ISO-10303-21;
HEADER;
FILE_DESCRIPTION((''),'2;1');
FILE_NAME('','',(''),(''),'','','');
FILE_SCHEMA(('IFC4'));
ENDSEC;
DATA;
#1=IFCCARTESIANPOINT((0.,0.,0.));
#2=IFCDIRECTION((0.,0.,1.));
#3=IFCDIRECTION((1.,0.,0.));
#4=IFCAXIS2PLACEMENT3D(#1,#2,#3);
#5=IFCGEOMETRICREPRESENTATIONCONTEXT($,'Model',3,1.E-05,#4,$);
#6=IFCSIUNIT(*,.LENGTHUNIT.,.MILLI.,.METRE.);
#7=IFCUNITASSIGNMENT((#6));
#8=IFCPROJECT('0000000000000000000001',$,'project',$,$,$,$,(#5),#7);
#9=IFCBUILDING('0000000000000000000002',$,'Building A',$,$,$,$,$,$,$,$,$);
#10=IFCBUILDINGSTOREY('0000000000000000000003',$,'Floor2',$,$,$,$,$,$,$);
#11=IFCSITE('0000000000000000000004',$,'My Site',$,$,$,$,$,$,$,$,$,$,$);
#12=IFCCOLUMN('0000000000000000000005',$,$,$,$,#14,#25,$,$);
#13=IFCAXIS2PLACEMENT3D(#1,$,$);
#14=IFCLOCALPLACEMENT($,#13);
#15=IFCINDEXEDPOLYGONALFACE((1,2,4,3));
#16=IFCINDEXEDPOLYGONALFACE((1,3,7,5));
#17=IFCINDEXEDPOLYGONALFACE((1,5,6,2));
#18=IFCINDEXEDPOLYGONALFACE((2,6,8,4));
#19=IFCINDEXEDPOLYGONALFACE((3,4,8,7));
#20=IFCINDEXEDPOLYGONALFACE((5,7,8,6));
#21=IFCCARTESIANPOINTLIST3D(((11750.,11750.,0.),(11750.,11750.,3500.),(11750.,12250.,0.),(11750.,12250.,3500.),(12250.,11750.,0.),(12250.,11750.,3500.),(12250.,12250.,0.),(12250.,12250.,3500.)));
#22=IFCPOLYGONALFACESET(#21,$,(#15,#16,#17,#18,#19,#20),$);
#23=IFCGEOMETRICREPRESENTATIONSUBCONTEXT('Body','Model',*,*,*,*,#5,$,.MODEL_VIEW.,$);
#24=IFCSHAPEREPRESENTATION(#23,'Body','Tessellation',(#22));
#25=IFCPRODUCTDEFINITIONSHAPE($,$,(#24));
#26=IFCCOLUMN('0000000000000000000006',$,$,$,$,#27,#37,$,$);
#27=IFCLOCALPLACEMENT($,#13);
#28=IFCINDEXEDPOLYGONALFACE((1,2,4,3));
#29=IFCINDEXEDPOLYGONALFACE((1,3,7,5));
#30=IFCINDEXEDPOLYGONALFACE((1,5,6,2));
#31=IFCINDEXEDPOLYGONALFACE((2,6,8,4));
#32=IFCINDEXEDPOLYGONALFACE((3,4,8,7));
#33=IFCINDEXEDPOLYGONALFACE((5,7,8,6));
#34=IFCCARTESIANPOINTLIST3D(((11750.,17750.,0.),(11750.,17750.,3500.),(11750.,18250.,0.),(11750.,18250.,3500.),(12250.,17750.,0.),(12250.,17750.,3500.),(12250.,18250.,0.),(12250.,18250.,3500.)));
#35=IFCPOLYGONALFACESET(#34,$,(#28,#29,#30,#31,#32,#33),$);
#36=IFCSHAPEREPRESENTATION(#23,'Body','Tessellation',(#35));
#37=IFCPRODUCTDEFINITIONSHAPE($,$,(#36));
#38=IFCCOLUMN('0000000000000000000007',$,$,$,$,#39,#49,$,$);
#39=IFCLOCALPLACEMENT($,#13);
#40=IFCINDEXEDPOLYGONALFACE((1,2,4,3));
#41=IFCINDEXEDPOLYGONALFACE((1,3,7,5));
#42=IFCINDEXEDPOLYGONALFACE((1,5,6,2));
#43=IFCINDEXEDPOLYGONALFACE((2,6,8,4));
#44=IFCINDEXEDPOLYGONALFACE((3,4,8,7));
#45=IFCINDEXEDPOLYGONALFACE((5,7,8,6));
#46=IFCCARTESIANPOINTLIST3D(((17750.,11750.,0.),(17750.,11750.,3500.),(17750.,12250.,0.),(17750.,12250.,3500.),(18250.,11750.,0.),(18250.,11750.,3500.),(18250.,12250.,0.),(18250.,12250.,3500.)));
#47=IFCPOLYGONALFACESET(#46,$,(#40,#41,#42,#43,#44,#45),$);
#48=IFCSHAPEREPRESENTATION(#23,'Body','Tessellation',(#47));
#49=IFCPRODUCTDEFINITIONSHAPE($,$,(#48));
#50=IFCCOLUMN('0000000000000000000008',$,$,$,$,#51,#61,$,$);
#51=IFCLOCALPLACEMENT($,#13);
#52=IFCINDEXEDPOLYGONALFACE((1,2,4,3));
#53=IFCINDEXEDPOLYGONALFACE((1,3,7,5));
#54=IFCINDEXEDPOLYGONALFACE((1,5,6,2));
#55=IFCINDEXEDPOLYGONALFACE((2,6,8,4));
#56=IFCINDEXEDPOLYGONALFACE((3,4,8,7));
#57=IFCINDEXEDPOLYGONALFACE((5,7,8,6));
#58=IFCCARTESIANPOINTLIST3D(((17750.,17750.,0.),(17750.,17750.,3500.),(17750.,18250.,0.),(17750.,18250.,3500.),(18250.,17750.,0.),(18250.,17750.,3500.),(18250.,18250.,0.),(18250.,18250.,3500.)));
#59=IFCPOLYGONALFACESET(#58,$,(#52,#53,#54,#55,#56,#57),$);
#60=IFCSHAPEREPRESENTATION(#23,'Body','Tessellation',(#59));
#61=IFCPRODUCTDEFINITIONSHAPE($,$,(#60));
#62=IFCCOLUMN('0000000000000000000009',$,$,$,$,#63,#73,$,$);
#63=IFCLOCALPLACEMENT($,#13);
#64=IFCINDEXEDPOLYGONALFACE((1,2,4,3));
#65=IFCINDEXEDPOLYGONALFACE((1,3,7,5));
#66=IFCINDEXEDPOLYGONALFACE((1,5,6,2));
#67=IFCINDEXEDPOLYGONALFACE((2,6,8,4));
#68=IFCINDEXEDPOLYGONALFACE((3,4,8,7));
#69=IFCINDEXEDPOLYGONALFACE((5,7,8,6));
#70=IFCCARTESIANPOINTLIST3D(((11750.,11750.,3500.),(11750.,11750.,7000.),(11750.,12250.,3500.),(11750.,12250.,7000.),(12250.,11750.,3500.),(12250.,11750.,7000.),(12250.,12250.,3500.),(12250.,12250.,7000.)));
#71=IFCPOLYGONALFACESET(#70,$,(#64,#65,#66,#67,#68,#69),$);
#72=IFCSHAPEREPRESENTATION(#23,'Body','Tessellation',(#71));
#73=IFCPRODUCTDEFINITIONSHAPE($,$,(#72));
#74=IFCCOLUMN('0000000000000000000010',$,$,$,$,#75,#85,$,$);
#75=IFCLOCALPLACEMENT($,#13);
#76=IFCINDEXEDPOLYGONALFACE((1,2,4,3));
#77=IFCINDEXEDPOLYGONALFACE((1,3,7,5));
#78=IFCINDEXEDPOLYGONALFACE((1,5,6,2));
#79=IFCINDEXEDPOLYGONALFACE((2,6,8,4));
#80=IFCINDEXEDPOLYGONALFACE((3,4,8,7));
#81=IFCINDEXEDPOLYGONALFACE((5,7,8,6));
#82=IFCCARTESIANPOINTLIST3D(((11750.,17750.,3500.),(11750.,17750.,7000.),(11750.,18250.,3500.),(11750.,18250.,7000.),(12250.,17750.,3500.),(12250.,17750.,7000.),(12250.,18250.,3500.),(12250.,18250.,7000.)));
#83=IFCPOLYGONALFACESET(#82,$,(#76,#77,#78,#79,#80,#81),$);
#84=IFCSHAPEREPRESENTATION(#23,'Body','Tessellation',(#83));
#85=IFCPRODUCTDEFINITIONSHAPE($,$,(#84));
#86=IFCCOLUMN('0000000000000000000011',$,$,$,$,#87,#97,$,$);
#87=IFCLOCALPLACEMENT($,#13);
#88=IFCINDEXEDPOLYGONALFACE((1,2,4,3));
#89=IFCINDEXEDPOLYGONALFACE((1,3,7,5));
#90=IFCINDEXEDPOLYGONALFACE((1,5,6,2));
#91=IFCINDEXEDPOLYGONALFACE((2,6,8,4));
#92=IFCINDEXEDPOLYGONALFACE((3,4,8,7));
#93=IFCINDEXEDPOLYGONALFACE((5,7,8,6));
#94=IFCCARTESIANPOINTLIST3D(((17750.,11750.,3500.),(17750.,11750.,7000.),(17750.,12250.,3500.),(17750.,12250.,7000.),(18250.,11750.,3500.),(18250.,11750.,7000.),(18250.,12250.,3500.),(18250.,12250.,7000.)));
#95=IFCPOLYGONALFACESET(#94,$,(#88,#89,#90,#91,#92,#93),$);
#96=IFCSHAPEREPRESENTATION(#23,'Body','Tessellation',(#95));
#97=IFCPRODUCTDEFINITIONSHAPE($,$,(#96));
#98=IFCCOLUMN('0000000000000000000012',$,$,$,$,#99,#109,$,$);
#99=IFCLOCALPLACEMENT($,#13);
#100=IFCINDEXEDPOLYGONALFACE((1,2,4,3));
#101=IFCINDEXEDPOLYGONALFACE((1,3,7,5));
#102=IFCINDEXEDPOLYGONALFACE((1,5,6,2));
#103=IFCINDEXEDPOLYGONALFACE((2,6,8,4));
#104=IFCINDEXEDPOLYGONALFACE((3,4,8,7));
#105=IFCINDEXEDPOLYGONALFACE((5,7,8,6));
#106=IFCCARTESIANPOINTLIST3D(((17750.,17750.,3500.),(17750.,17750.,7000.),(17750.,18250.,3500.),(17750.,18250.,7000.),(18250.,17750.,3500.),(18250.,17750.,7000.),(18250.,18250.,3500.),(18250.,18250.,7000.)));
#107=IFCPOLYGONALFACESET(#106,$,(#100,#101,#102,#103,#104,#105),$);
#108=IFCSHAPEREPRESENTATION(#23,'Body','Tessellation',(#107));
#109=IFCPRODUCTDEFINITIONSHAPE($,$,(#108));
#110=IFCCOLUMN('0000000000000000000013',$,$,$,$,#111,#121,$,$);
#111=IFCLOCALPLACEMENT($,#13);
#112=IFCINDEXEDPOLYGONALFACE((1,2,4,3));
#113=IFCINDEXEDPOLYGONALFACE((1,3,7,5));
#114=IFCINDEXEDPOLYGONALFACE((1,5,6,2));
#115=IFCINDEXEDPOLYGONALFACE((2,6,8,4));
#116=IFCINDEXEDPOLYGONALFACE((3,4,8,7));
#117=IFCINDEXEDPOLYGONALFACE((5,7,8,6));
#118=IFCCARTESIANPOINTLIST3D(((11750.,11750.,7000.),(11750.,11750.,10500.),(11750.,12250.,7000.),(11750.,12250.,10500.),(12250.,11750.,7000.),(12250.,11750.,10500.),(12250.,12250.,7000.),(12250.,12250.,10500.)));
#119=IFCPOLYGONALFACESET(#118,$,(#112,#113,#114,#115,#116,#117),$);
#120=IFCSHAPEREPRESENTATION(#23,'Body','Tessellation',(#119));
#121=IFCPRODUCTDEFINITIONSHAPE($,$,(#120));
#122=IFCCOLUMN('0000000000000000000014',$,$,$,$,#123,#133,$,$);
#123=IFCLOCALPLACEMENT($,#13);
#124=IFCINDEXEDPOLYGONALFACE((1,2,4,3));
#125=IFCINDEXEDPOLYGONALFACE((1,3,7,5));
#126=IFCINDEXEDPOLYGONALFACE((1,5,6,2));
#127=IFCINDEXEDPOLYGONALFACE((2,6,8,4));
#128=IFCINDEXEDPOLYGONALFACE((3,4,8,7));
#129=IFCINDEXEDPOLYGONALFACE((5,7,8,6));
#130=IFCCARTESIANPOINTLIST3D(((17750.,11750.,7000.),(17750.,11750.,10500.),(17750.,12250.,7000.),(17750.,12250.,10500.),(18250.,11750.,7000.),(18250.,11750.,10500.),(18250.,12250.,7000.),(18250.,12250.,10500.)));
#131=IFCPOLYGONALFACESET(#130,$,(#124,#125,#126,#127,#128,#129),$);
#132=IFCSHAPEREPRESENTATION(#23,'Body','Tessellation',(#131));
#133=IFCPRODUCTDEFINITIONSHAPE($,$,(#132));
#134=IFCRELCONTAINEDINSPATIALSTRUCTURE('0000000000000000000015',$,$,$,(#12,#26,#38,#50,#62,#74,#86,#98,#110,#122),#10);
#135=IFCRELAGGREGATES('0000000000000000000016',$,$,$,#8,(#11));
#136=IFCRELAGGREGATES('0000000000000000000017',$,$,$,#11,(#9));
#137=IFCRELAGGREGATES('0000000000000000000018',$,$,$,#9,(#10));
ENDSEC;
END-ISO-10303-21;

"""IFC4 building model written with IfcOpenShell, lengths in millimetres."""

from ifc_helpers import new_model, si_unit, frame, origin_with_axes, place, context, subcontext, project, spatial, line, indexed_curve, outline, extrude, element, save


model = new_model("IFC4")

# Units and contexts
model_context = context("Model", 3, precision=1e-05, world=origin_with_axes())
body_context = subcontext(model_context, "Body", "Model", "MODEL_VIEW")
ifc_project = project(units=[si_unit("LENGTHUNIT", "METRE", prefix="MILLI")], contexts=[model_context])

# Site, building, storey
site = spatial("IfcSite", under=ifc_project, Name="My Site")
building = spatial("IfcBuilding", under=site, Name="Building A")
storey = spatial("IfcBuildingStorey", under=building, Name="Floor2")

# Columns
for number, where, z_axis, x_axis in (
    (1, (12000.0, 12000.0, 0.0), (0.0, 0.0, 1.0), (1.0, 0.0, 0.0)),
    (2, (12000.0, 18000.0, 0.0), (0.0, 0.0, 1.0), (1.0, 0.0, 0.0)),
    (3, (18000.0, 12000.0, 0.0), (0.0, 0.0, 1.0), (1.0, 0.0, 0.0)),
    (4, (18000.0, 18000.0, 0.0), (0.0, 0.0, 1.0), (1.0, 0.0, 0.0)),
    (5, (12000.0, 12000.0, 3500.0), (0.0, 0.0, 1.0), (1.0, 0.0, 0.0)),
    (6, (12000.0, 18000.0, 3500.0), (0.0, 0.0, 1.0), (1.0, 0.0, 0.0)),
    (7, (18000.0, 12000.0, 3500.0), (0.0, 0.0, 1.0), (1.0, 0.0, 0.0)),
    (8, (18000.0, 18000.0, 3500.0), (0.0, 0.0, 1.0), (1.0, 0.0, 0.0)),
    (9, (12000.0, 12000.0, 7000.0), (0.0, 0.0, 1.0), (1.0, 0.0, 0.0)),
    (10, (18000.0, 12000.0, 7000.0), (0.0, 0.0, 1.0), (1.0, 0.0, 0.0)),
):
    element("IfcColumn", number, at=place(None, frame(where, z_axis=z_axis, x_axis=x_axis)), inside=storey, context=body_context, shape_type="SweptSolid", body=[
        extrude(outline(indexed_curve([(-250.0, -250.0), (250.0, -250.0), (250.0, 250.0), (-250.0, 250.0)], segments=[line(1, 2, 3, 4, 1)])), origin_with_axes(), (0.0, 0.0, 1.0), 3500.0),
    ])

save(model, "model.ifc")
